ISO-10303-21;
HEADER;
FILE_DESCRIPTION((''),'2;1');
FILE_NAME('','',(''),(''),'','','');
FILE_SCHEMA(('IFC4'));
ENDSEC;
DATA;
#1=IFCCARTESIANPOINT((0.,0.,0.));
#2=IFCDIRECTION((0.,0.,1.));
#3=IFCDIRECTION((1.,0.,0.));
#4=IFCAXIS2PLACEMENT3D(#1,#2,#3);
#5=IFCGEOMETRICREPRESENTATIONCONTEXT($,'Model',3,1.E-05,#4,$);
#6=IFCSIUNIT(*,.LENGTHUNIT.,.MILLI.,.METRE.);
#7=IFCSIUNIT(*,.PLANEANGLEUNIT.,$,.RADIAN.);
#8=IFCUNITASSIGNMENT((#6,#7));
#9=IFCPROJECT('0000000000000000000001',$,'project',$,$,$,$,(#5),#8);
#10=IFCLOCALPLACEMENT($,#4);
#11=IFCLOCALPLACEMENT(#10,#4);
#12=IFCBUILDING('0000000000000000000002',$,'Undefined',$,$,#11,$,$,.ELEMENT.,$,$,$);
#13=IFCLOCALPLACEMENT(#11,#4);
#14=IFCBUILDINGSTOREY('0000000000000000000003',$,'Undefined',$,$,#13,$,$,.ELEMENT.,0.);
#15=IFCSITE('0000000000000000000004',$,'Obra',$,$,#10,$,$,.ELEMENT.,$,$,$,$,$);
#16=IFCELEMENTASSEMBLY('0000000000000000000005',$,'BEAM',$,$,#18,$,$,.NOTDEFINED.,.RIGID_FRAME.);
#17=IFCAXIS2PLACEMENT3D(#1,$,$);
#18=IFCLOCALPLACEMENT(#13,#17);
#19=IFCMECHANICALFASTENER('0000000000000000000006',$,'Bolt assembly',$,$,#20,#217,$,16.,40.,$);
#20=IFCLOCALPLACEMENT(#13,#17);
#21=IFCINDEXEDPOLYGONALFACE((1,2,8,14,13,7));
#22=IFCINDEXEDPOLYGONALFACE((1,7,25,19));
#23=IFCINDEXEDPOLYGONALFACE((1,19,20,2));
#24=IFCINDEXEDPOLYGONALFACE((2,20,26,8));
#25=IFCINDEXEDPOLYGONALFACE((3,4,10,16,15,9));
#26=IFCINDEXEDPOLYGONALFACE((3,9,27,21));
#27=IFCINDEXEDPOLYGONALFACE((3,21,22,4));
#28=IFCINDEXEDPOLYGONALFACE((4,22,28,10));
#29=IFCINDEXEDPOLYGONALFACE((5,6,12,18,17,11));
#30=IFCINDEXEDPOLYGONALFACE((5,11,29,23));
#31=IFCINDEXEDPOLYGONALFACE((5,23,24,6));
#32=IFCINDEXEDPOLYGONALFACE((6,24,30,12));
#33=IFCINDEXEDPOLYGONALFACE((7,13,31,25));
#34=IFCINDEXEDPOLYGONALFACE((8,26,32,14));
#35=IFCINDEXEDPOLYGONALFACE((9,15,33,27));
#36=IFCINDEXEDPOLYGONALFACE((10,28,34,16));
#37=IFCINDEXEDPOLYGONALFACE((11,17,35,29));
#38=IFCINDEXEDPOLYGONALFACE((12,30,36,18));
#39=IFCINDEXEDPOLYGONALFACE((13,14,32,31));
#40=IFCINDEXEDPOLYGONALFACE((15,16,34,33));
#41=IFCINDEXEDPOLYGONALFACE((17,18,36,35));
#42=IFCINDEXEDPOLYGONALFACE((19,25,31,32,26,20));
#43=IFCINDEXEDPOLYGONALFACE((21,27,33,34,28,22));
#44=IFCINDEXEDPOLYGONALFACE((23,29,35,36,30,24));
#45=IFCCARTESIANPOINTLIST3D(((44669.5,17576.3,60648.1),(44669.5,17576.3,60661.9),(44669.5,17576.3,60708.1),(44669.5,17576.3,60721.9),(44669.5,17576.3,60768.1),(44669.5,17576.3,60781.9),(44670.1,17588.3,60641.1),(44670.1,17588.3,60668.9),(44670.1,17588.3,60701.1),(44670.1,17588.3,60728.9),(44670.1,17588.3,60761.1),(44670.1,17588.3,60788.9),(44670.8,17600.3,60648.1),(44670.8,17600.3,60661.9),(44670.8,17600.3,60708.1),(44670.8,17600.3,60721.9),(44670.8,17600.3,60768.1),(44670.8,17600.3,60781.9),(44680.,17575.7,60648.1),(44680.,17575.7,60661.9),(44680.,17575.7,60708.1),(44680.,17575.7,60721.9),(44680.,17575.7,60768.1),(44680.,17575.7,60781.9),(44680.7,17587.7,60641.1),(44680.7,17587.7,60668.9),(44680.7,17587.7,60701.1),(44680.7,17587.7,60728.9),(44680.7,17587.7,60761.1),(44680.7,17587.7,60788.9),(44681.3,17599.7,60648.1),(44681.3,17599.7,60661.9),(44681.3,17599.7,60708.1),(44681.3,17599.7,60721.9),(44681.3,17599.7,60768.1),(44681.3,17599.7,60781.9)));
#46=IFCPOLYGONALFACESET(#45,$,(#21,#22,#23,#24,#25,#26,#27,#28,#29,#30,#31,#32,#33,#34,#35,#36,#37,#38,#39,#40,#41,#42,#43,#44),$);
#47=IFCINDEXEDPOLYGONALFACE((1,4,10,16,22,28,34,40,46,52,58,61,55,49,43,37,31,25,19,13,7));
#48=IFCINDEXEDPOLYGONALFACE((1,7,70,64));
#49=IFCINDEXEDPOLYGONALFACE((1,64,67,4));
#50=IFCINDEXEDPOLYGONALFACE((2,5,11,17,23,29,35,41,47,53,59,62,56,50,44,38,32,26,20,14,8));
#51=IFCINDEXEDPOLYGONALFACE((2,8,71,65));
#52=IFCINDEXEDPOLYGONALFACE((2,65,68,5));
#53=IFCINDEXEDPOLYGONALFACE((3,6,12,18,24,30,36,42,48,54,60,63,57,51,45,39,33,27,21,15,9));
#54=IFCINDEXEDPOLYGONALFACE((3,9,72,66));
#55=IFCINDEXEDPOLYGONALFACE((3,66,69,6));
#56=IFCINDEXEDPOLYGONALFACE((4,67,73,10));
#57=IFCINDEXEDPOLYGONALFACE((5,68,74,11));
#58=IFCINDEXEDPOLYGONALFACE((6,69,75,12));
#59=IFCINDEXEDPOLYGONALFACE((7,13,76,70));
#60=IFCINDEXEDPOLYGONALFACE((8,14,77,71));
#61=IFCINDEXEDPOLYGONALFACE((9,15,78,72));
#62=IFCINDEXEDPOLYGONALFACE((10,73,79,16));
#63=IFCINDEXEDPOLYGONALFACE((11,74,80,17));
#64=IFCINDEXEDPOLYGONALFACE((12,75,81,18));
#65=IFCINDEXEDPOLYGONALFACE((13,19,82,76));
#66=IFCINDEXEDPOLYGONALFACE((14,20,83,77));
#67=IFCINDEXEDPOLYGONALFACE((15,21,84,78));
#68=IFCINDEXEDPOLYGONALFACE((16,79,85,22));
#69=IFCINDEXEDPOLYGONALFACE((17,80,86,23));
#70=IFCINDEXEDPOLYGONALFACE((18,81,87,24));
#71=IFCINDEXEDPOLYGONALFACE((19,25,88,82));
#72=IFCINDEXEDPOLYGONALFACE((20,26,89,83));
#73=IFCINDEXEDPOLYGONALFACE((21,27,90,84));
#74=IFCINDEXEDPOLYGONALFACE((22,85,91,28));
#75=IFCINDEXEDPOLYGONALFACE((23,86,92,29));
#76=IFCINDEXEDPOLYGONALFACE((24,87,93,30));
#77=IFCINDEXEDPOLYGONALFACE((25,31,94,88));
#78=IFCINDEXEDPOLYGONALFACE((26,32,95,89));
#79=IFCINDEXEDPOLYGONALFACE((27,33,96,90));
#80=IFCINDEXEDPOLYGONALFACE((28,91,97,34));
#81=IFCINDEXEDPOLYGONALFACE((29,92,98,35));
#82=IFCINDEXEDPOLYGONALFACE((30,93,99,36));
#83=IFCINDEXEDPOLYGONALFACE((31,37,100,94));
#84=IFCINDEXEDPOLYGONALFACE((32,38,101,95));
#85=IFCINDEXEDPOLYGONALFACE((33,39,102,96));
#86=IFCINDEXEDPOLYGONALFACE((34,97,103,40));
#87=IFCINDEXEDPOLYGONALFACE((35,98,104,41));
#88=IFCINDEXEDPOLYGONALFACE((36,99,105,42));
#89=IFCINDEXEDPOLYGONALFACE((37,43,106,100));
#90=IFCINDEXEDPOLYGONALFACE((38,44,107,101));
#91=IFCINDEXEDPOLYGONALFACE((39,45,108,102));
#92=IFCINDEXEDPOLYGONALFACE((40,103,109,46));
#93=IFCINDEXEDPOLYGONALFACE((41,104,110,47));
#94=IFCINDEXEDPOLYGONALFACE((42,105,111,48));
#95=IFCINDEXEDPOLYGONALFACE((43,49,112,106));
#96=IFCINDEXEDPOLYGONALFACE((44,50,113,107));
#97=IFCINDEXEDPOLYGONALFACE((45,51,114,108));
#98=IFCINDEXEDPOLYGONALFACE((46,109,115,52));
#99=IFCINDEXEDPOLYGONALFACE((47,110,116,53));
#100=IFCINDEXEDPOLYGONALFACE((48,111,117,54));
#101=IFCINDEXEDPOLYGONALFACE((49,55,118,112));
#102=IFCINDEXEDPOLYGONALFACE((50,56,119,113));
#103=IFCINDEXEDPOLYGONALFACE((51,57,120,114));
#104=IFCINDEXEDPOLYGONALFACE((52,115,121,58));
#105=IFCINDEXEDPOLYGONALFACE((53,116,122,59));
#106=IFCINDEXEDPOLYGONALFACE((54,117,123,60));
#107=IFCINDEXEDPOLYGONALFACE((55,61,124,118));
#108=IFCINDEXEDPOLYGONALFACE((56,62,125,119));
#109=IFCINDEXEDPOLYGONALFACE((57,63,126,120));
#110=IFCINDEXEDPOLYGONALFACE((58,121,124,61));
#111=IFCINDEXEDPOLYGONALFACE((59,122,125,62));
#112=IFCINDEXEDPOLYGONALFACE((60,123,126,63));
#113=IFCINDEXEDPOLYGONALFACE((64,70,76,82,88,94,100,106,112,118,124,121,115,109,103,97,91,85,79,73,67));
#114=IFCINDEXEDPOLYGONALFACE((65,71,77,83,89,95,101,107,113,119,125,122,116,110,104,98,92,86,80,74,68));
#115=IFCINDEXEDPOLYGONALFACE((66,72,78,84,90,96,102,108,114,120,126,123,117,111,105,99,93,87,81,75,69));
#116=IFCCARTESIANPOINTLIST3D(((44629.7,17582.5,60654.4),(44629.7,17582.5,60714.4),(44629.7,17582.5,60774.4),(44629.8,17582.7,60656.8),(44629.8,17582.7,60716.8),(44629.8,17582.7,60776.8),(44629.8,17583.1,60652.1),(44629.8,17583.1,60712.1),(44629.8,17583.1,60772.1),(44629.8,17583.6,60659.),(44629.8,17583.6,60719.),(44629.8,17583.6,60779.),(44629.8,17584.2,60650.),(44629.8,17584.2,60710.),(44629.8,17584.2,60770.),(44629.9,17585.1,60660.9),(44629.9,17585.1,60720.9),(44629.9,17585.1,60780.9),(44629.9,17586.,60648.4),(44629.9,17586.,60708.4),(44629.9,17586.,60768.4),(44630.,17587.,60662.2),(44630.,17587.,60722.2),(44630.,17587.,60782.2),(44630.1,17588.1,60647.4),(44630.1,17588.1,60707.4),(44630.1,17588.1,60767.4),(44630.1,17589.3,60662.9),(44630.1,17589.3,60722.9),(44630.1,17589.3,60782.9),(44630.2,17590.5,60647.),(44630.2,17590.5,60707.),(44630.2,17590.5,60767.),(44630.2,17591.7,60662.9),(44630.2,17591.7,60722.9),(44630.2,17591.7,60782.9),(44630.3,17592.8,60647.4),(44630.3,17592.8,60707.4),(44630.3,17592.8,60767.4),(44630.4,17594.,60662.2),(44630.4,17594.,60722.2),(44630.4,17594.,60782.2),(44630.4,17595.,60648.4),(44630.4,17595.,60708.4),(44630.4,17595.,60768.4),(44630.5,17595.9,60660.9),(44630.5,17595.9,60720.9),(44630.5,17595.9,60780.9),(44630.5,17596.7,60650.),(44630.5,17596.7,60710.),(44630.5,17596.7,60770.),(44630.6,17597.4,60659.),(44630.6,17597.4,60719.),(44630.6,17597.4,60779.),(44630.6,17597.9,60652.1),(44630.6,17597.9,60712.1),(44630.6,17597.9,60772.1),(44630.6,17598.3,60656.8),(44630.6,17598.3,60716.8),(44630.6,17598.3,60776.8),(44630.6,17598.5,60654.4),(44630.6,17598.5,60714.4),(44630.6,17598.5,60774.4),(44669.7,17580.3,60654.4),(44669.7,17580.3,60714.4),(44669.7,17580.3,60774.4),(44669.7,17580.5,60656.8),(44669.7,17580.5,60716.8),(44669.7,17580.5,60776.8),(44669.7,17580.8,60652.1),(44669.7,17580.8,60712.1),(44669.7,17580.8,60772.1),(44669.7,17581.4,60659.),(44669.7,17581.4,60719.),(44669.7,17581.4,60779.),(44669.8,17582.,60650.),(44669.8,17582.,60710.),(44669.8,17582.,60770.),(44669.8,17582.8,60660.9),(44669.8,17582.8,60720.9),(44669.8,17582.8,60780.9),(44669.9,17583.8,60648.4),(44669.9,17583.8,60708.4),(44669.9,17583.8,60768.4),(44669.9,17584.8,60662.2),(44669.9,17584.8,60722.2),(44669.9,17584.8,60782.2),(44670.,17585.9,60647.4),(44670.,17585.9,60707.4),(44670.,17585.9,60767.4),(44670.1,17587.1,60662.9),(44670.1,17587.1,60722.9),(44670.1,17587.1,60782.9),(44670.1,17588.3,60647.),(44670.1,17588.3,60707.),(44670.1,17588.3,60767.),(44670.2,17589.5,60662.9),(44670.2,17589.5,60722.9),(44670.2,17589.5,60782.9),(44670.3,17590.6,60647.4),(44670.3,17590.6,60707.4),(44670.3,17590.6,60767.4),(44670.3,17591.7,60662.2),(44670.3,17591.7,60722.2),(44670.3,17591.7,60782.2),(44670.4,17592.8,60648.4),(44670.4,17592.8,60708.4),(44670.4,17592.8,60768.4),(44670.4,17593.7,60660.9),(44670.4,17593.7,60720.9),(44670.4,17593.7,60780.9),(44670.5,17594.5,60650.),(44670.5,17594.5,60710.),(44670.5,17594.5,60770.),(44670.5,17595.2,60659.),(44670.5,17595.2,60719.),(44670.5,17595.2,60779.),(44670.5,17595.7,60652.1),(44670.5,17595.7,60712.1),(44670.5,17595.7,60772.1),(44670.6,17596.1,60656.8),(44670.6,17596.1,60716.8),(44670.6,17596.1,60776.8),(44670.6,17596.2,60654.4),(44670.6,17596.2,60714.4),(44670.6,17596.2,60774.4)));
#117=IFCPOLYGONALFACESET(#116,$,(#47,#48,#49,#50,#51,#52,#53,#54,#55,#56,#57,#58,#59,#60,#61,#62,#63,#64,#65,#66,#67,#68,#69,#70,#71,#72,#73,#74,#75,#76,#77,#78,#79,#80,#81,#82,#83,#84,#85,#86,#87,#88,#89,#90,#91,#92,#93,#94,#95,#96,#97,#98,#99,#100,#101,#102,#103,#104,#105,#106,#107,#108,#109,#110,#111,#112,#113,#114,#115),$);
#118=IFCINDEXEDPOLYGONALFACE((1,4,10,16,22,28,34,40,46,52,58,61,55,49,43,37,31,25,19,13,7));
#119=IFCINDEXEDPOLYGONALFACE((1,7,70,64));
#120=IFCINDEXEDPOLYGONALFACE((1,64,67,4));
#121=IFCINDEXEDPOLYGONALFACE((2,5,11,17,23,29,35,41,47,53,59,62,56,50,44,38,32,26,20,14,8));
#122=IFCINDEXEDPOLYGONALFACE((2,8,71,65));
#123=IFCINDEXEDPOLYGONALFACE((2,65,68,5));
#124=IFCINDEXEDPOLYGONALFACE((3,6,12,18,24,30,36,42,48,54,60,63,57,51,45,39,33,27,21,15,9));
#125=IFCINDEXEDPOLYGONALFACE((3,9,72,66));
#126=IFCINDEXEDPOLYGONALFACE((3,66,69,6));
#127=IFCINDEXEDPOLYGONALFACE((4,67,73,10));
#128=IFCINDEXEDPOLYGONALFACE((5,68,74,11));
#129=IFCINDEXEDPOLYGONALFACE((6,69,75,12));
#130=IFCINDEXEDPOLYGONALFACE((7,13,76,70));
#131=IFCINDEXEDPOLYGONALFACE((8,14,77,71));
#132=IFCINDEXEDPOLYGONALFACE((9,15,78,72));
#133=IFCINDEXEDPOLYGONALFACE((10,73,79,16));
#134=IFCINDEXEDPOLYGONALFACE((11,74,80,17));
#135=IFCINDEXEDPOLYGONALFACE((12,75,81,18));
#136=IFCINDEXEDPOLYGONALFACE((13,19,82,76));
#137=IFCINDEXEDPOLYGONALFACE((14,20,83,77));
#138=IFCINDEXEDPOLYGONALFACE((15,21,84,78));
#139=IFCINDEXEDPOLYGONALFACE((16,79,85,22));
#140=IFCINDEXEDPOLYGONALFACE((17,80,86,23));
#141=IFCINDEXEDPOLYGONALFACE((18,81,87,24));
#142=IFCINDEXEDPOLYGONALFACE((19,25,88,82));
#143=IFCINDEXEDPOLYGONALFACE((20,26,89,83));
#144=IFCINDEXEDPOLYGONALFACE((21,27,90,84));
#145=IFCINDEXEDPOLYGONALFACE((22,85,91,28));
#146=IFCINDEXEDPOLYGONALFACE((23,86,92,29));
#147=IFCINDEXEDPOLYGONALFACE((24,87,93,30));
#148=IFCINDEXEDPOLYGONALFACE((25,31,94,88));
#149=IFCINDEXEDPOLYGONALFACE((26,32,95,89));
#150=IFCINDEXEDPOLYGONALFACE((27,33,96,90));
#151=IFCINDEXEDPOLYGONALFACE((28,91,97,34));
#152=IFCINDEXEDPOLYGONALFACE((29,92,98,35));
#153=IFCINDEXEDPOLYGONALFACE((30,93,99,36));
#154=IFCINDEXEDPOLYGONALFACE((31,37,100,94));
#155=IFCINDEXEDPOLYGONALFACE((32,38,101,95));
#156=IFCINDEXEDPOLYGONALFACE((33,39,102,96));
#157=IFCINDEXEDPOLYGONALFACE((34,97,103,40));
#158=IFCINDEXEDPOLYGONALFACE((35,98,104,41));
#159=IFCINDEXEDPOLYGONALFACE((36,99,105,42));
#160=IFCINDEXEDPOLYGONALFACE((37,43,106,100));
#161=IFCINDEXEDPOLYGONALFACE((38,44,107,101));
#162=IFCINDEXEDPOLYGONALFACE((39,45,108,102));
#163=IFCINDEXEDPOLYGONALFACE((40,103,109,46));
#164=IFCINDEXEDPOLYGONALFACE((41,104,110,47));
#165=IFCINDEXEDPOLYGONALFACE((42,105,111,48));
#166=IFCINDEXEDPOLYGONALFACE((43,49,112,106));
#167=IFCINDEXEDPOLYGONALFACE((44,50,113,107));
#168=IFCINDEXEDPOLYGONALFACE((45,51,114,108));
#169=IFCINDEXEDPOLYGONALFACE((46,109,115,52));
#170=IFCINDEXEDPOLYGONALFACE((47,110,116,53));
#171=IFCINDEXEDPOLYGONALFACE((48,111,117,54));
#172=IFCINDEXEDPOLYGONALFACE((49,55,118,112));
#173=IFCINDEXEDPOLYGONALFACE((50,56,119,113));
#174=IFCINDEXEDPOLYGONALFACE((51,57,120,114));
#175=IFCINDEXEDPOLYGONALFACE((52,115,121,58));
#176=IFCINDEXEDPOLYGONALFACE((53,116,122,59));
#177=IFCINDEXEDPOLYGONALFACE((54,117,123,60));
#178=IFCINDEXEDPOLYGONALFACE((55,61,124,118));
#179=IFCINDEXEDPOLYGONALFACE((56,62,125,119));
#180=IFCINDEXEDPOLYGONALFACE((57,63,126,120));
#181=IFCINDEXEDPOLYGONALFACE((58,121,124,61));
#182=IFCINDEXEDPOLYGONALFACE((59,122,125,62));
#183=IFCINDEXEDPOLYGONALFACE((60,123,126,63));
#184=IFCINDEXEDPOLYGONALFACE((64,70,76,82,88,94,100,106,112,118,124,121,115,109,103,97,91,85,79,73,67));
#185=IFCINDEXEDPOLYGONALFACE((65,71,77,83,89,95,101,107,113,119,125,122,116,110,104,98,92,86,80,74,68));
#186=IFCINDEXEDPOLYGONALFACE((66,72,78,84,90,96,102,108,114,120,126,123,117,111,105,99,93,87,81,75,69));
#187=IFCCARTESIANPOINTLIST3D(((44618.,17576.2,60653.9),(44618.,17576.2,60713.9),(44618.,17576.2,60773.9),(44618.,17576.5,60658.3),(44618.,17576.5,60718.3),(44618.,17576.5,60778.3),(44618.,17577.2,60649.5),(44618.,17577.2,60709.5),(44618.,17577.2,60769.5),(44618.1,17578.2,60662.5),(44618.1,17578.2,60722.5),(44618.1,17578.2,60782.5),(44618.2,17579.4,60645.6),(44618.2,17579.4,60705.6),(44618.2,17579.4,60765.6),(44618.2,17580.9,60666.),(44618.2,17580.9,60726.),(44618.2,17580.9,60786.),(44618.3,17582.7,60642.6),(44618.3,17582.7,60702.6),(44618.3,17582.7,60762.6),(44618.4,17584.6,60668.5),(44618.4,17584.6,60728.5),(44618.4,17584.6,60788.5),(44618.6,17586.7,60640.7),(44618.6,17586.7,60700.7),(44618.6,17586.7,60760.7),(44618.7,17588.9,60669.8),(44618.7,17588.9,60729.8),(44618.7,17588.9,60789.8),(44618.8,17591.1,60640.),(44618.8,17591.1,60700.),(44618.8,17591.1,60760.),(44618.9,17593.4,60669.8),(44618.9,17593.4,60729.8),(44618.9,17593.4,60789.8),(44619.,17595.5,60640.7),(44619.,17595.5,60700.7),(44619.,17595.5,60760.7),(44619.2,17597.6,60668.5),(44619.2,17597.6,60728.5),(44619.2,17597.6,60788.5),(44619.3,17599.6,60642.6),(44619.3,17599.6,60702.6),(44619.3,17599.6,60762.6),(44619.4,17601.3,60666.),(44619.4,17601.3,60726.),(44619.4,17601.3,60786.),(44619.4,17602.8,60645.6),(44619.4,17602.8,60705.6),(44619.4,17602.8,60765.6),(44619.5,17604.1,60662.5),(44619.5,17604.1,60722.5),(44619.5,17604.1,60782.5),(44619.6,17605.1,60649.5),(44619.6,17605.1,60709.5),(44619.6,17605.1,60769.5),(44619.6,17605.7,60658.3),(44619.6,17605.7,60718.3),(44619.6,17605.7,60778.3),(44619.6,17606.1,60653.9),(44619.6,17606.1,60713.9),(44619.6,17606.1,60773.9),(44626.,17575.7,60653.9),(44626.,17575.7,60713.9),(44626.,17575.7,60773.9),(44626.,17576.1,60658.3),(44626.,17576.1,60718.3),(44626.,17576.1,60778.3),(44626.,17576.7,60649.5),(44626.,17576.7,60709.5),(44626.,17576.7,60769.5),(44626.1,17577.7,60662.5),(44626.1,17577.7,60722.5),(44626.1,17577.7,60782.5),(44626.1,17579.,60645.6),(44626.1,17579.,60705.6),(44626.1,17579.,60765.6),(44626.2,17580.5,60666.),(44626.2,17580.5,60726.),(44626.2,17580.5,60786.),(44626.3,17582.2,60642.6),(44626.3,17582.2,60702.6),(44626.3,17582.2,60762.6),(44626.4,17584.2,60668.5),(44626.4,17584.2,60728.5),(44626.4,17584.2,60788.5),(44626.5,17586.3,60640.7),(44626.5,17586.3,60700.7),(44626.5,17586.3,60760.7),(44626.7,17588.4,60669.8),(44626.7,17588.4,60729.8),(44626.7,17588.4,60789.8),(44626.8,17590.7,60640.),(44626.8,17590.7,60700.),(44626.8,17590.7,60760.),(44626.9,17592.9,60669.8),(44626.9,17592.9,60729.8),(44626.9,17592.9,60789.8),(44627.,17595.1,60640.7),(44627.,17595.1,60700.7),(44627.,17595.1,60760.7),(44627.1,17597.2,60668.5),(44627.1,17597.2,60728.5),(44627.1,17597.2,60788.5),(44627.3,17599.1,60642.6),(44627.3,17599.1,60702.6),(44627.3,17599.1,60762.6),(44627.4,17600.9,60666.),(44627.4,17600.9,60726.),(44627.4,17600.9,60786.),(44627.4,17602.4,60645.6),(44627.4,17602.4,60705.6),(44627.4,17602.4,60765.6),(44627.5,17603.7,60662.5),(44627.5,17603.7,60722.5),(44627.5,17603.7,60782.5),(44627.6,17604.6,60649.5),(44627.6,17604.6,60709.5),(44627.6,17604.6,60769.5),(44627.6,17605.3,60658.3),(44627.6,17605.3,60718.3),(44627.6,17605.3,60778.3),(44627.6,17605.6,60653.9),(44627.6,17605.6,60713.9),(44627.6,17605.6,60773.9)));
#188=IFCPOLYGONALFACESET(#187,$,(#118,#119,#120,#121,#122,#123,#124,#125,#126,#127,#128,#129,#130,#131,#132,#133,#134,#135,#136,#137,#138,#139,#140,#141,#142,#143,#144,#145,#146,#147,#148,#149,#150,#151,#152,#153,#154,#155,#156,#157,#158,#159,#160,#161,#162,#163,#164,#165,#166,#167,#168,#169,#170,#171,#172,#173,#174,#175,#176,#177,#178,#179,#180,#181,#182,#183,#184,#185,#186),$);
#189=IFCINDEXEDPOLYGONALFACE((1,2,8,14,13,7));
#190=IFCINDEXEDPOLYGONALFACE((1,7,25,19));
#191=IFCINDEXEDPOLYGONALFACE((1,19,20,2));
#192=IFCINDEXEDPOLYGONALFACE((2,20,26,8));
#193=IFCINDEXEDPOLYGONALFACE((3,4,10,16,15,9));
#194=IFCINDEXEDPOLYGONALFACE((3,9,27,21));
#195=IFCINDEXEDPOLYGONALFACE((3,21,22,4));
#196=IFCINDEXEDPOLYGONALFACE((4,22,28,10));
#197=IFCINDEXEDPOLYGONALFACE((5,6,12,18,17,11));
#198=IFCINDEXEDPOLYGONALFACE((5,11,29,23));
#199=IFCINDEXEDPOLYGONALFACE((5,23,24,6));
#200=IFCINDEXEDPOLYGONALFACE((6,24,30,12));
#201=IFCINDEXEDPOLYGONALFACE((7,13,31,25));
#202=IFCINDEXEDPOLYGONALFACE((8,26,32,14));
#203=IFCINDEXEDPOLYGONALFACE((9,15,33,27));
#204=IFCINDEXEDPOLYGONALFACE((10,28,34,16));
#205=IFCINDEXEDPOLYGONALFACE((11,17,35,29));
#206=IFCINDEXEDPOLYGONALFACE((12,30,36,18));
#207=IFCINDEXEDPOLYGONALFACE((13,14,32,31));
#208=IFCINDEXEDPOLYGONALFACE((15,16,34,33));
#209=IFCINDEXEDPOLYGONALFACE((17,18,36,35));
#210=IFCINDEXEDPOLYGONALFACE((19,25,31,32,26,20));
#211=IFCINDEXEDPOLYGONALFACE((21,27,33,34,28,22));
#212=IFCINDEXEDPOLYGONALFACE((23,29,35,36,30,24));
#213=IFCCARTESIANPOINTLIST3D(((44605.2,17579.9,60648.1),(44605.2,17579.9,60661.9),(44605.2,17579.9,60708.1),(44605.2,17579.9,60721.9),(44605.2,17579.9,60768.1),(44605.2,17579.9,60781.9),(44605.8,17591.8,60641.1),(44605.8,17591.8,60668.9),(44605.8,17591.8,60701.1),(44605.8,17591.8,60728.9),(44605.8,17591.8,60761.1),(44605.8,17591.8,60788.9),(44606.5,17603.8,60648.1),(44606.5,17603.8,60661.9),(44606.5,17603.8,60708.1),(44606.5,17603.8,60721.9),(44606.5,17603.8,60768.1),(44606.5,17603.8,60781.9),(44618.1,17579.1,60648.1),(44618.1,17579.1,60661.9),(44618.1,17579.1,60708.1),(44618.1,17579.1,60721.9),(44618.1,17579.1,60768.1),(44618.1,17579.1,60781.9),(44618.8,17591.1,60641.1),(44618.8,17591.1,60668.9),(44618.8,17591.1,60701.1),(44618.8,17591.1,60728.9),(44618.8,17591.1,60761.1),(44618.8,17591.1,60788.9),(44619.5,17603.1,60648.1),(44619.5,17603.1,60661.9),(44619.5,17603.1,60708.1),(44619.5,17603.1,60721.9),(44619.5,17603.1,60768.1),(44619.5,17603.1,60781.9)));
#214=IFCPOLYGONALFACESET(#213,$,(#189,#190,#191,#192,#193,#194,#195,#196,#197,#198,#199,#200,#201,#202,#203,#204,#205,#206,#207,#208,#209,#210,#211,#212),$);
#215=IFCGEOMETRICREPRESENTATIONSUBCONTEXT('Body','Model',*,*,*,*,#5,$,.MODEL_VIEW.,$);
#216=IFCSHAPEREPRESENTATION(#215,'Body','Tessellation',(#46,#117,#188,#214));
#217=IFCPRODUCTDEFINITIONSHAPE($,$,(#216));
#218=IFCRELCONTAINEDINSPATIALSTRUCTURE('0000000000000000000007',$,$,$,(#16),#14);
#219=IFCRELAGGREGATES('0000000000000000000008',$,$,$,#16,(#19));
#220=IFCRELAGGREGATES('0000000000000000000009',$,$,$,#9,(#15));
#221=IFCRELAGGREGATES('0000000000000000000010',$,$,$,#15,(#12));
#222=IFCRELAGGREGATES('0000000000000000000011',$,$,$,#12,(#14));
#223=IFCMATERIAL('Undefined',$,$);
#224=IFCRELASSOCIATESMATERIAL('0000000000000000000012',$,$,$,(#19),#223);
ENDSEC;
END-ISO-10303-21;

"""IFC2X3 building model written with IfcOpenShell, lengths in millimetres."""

from ifc_helpers import new_model, si_unit, frame, origin_with_axes, origin_2d_with_axis, place, context, subcontext, project, spatial, polyline, circle, outline, extrude, source, transform, mapped, material, element, aggregate, save


model = new_model("IFC2X3")

# Units and contexts
model_context = context("Model", 3, precision=1e-05, world=origin_with_axes())
body_context = subcontext(model_context, "Body", "Model", "MODEL_VIEW")
ifc_project = project(units=[si_unit("LENGTHUNIT", "METRE", prefix="MILLI"), si_unit("PLANEANGLEUNIT", "RADIAN")], contexts=[model_context])

# Site, building, storey
site_placement = place(None, origin_with_axes())
site = spatial("IfcSite", under=ifc_project, at=site_placement, Name="Obra", CompositionType="ELEMENT")
building_placement = place(site_placement, origin_with_axes())
building = spatial("IfcBuilding", under=site, at=building_placement, Name="Undefined", CompositionType="ELEMENT")
storey_placement = place(building_placement, origin_with_axes())
storey = spatial("IfcBuildingStorey", under=building, at=storey_placement, Name="Undefined", CompositionType="ELEMENT", Elevation=0.0)

# Element assembly, mechanical fastener
ifc_material_1 = material(Name="Undefined")
shared_shape_1 = source(origin_with_axes(), body_context, "Body", "SweptSolid", [
    extrude(outline(polyline([(13.9, 0.0), (6.9, 12.0), (-6.9, 12.0), (-13.9, 0.0), (-6.9, -12.0), (6.9, -12.0), (13.9, 0.0)])), frame((0.0, -19.7, 0.0), z_axis=(0.0, 1.0, 0.0), x_axis=(1.0, 0.0, 0.0)), (0.0, 0.0, 1.0), 10.6),
    extrude(circle(Radius=8.0, at=origin_2d_with_axis()), frame((0.0, -9.1, 0.0), z_axis=(0.0, 1.0, 0.0), x_axis=(1.0, 0.0, 0.0)), (0.0, 0.0, 1.0), 40.0),
    extrude(circle(Radius=15.0, at=origin_2d_with_axis()), frame((0.0, 34.3, 0.0), z_axis=(0.0, 1.0, 0.0), x_axis=(1.0, 0.0, 0.0)), (0.0, 0.0, 1.0), 8.0),
    extrude(outline(polyline([(13.9, 0.0), (6.9, 12.0), (-6.9, 12.0), (-13.9, 0.0), (-6.9, -12.0), (6.9, -12.0), (13.9, 0.0)])), frame((0.0, 42.3, 0.0), z_axis=(0.0, 1.0, 0.0), x_axis=(1.0, 0.0, 0.0)), (0.0, 0.0, 1.0), 13.0),
])
assembly_1_placement = place(storey_placement, origin_with_axes())
assembly_1 = element("IfcElementAssembly", 1, at=assembly_1_placement, inside=storey, Name="BEAM", AssemblyPlace="NOTDEFINED", PredefinedType="RIGID_FRAME")
mechanical_fastener_1_placement = place(assembly_1_placement, frame((44658.3, 17538.9, 60835.0), z_axis=(0.055268, 0.998472, 0.0), x_axis=(0.0, 0.0, -1.0)))
mechanical_fastener_1 = element("IfcMechanicalFastener", 2, at=mechanical_fastener_1_placement, material=ifc_material_1, Name="Bolt assembly", NominalDiameter=16.0, NominalLength=40.0, context=body_context, shape_type="MappedRepresentation", body=[
    mapped(shared_shape_1, transform((60.0, 0.0, 50.0))),
    mapped(shared_shape_1, transform((120.0, 0.0, 50.0))),
    mapped(shared_shape_1, transform((180.0, 0.0, 50.0))),
])

aggregate(assembly_1, [mechanical_fastener_1])

save(model, "model.ifc")
